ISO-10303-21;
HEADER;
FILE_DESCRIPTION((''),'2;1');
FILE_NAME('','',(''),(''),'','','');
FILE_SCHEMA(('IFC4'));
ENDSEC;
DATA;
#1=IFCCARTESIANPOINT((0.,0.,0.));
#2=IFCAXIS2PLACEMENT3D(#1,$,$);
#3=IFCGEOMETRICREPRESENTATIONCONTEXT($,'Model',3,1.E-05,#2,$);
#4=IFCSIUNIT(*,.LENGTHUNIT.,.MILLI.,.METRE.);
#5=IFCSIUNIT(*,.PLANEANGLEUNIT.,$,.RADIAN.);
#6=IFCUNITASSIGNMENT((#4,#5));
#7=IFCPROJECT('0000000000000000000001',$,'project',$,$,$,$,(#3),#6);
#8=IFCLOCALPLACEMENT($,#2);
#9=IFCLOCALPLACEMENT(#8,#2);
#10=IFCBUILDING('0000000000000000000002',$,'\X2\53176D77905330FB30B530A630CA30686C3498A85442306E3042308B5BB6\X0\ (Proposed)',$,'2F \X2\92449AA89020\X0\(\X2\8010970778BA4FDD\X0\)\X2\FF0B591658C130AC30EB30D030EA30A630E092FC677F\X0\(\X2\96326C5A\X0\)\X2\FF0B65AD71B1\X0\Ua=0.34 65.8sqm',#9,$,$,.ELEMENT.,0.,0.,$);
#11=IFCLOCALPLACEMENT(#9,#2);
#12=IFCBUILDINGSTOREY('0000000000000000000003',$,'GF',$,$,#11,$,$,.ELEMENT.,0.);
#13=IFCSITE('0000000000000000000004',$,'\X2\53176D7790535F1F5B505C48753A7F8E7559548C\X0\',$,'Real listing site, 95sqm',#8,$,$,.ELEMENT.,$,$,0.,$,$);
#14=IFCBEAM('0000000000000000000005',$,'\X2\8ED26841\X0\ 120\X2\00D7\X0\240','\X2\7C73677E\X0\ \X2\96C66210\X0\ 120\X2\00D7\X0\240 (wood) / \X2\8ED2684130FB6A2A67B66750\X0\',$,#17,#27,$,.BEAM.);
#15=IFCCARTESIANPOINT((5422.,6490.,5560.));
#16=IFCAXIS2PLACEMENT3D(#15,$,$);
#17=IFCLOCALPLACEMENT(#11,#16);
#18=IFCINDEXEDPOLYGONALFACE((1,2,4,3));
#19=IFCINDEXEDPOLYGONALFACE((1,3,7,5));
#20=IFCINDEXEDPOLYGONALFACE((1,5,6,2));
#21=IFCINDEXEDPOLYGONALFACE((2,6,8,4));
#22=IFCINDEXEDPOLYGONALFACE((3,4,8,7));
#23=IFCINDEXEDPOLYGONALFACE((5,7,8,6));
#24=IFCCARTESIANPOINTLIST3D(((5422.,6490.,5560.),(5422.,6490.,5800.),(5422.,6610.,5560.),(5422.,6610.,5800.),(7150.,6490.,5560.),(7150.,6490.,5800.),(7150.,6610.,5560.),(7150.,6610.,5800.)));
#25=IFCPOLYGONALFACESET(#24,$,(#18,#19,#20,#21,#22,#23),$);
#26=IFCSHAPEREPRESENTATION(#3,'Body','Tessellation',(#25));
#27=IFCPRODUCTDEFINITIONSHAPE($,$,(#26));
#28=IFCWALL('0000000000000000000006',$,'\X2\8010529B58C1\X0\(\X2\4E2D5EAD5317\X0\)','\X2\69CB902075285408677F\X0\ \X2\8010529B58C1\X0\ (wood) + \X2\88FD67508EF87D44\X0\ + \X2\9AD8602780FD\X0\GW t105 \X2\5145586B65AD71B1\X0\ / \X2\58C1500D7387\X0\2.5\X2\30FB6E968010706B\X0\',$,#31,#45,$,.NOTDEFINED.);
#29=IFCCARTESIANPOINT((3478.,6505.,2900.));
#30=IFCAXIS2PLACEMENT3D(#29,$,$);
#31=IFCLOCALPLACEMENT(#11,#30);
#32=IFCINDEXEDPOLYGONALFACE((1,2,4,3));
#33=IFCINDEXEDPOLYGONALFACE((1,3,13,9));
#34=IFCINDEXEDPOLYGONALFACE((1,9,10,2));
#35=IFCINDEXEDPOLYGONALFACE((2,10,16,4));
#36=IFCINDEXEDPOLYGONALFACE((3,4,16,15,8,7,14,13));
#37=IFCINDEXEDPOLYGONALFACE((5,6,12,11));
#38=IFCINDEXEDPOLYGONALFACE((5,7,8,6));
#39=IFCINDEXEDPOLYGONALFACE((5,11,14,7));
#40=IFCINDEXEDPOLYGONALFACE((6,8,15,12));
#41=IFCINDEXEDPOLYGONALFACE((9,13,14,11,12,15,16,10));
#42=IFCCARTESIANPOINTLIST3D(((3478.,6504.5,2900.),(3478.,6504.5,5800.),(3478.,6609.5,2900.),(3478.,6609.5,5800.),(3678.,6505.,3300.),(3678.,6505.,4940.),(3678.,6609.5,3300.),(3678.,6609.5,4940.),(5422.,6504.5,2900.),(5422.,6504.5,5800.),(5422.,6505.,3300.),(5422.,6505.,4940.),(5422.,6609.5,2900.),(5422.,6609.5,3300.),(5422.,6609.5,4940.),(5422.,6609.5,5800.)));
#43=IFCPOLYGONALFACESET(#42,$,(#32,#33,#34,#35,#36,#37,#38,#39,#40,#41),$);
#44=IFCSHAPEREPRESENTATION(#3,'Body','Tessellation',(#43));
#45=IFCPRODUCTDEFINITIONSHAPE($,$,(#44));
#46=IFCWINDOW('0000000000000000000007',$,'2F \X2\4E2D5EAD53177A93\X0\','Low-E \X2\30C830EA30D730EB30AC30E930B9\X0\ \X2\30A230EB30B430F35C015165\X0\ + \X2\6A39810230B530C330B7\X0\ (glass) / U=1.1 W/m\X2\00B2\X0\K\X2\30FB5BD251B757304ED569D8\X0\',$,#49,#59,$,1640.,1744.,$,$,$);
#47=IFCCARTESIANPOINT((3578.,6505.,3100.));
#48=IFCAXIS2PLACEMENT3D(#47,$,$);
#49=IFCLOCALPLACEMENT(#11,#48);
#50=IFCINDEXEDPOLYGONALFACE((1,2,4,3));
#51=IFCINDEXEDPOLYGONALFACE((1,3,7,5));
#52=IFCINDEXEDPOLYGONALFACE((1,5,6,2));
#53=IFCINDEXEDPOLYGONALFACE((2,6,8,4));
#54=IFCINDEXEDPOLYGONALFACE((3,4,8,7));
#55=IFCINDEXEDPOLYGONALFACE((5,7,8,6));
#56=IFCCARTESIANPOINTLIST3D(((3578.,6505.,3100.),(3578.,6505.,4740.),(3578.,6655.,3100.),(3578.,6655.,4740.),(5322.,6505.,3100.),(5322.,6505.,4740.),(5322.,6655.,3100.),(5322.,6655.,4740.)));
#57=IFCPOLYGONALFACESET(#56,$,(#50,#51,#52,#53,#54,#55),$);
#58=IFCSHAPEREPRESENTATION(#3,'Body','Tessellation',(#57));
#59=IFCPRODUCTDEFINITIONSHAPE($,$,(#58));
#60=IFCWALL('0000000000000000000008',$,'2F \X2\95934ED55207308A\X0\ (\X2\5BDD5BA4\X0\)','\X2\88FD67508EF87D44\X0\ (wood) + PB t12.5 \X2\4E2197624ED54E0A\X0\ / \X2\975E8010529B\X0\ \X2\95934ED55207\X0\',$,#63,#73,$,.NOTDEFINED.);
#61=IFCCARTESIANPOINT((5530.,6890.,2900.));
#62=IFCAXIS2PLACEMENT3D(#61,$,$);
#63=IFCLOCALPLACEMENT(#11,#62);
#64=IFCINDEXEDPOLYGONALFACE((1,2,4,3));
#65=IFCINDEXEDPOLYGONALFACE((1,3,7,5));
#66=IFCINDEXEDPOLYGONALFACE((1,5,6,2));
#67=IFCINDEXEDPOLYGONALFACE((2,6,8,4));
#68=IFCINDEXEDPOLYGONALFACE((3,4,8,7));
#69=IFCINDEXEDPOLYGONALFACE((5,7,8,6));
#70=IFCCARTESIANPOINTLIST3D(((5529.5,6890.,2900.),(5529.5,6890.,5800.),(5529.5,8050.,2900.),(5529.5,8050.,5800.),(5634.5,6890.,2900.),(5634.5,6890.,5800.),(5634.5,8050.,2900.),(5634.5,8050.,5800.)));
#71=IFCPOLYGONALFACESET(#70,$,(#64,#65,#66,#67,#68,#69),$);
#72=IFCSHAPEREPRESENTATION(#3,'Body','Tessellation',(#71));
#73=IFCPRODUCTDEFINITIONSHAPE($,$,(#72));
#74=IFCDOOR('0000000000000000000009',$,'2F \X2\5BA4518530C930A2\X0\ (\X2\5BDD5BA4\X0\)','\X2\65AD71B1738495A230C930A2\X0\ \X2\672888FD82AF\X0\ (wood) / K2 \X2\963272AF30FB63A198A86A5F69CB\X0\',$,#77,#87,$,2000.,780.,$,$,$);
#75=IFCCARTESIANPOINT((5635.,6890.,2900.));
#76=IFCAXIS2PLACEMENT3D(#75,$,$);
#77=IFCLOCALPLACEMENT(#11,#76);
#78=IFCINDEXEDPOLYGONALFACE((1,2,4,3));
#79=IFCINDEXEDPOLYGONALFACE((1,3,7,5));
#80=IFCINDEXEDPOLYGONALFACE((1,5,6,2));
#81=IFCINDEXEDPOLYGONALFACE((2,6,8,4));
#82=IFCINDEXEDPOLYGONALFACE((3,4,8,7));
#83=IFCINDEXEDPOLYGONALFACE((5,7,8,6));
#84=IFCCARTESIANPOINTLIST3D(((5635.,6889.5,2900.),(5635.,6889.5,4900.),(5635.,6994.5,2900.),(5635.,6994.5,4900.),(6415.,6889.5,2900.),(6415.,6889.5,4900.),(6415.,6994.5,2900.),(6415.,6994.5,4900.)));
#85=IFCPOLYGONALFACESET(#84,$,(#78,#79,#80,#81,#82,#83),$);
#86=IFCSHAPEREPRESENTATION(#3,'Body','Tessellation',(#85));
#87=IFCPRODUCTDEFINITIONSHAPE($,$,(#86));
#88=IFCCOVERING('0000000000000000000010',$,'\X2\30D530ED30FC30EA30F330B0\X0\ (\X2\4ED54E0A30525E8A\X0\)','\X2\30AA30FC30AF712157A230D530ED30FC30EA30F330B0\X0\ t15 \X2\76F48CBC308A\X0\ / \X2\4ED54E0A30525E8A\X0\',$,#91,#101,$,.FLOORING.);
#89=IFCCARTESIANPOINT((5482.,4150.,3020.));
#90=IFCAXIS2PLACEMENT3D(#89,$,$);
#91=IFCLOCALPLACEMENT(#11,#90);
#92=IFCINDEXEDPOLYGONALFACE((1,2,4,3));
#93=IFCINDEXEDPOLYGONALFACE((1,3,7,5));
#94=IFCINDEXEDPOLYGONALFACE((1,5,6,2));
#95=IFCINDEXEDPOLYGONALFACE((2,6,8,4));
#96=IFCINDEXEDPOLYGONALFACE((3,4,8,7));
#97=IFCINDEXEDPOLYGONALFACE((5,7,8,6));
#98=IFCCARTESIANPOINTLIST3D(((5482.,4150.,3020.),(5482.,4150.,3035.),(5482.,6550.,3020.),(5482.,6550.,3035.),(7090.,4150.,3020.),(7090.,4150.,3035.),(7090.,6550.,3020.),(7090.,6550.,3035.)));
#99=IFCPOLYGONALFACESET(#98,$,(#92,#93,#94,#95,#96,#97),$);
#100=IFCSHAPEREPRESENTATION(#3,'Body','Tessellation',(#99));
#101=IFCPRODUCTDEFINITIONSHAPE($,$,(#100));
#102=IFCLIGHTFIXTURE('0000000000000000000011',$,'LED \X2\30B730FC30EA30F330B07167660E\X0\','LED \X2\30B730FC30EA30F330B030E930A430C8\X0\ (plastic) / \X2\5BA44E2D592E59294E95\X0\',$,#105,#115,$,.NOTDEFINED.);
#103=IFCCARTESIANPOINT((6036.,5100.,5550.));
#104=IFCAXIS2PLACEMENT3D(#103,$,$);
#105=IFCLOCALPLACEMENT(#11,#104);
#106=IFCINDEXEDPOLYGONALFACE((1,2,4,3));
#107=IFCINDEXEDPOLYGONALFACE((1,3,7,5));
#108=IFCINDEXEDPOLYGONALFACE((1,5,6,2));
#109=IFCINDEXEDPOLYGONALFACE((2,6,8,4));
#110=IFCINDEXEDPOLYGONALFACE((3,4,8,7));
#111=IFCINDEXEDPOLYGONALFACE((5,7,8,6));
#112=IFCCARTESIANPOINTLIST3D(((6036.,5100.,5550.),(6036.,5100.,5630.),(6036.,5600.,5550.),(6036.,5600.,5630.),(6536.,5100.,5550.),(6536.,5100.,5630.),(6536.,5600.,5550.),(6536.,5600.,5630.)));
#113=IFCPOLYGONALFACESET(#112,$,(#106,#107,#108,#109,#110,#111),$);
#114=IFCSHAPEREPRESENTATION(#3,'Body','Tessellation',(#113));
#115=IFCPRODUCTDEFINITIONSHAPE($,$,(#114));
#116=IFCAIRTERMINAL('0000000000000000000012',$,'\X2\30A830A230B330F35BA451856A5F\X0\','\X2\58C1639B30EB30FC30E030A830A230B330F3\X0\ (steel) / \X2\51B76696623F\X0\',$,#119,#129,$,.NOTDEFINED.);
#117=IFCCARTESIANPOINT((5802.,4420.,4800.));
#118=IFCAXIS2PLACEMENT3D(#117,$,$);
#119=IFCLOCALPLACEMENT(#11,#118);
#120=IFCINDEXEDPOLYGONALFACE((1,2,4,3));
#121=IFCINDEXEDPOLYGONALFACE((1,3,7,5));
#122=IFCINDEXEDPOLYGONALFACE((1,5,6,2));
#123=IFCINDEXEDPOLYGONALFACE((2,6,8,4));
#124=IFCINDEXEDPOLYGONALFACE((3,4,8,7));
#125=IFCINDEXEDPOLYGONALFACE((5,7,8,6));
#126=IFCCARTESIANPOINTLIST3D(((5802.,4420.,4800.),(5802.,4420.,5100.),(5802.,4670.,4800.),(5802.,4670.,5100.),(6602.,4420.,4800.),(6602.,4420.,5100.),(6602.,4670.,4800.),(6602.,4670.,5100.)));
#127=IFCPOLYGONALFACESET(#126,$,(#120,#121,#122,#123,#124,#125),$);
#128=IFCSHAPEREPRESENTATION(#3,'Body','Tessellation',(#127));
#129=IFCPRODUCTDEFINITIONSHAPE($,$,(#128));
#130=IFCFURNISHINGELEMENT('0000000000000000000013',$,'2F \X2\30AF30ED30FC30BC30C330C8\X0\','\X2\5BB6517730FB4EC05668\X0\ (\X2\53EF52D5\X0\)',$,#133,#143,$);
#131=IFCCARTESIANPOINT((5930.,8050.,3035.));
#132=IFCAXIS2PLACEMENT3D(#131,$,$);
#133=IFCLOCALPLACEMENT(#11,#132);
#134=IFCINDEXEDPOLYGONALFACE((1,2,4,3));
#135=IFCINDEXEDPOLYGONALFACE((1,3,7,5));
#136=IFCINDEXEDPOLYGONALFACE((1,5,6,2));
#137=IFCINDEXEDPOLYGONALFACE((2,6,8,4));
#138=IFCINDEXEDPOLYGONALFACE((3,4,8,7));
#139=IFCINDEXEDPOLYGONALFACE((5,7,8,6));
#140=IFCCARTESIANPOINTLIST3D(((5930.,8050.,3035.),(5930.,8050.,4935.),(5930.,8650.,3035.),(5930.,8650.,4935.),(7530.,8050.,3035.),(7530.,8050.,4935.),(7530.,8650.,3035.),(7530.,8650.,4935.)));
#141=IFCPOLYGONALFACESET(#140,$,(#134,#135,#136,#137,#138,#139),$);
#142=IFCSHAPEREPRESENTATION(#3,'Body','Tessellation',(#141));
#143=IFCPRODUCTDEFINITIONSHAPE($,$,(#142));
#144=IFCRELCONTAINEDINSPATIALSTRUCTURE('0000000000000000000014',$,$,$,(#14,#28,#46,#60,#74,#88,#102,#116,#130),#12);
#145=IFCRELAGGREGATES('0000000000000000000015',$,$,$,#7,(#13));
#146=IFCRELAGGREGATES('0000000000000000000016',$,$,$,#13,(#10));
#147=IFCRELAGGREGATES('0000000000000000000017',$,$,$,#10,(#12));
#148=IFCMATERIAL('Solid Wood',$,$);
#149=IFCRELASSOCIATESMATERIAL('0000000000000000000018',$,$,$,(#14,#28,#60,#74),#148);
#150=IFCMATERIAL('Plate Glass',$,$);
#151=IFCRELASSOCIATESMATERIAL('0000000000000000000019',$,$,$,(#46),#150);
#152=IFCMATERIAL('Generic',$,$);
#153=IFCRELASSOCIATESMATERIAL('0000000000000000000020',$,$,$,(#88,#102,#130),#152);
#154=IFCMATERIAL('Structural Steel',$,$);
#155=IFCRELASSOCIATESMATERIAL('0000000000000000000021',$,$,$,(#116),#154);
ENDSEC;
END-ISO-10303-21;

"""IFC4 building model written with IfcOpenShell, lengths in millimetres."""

from ifc_helpers import new_model, si_unit, frame, frame_2d, origin, place, context, project, spatial, rectangle, extrude, material, element, fill, save


model = new_model("IFC4")

# Units and contexts
model_context = context("Model", 3, precision=1e-05, world=origin())
ifc_project = project(units=[si_unit("LENGTHUNIT", "METRE", prefix="MILLI"), si_unit("PLANEANGLEUNIT", "RADIAN")], contexts=[model_context])

# Site, building, storey
site_placement = place(None, origin())
site = spatial("IfcSite", under=ifc_project, at=site_placement, Name="北海道弟子屈町美留和", ObjectType="Real listing site, 95sqm", CompositionType="ELEMENT", RefElevation=0.0)
building_placement = place(site_placement, origin())
building = spatial("IfcBuilding", under=site, at=building_placement, Name="北海道・サウナと水風呂のある家 (Proposed)", ObjectType="2F 鉄骨造(耐震確保)＋外壁ガルバリウム鋼板(防汚)＋断熱Ua=0.34 65.8sqm", CompositionType="ELEMENT", ElevationOfRefHeight=0.0, ElevationOfTerrain=0.0)
storey_placement = place(building_placement, origin())
storey = spatial("IfcBuildingStorey", under=building, at=storey_placement, Name="GF", CompositionType="ELEMENT", Elevation=0.0)

# Shared definitions
ifc_material_1 = material(Name="Solid Wood")

# Beam
beam_1_placement = place(storey_placement, frame((5422.0, 6490.0, 5560.0)))
element("IfcBeam", 1, at=beam_1_placement, inside=storey, material=ifc_material_1, Name="軒桁 120×240", Description="米松 集成 120×240 (wood) / 軒桁・横架材", PredefinedType="BEAM", context=model_context, shape_type="SweptSolid", body=[
    extrude(rectangle(XDim=1728.0, YDim=120.0, at=frame_2d((864.0, 60.0))), frame((5422.0, 6490.0, 5560.0)), (0.0, 0.0, 1.0), 240.0),
])

# Wall, opening, window
wall_1_placement = place(storey_placement, frame((3478.0, 6505.0, 2900.0)))
wall_1 = element("IfcWall", 2, at=wall_1_placement, inside=storey, material=ifc_material_1, Name="耐力壁(中庭北)", Description="構造用合板 耐力壁 (wood) + 製材軸組 + 高性能GW t105 充填断熱 / 壁倍率2.5・準耐火", PredefinedType="NOTDEFINED", context=model_context, shape_type="SweptSolid", body=[
    extrude(rectangle(XDim=1944.0, YDim=105.0, at=frame_2d((972.0, 52.0))), frame((3478.0, 6505.0, 2900.0)), (0.0, 0.0, 1.0), 2900.0),
])
opening_placement = place(storey_placement, frame((3578.0, 6505.0, 3100.0)))
opening = element("IfcOpeningElement", 3, at=opening_placement, cuts=wall_1, PredefinedType="NOTDEFINED", context=model_context, shape_type="SweptSolid", body=[
    extrude(rectangle(XDim=1744.0, YDim=150.0, at=frame_2d((872.0, 75.0))), frame((3578.0, 6505.0, 3100.0)), (0.0, 0.0, 1.0), 1640.0),
])
ifc_material_2 = material(Name="Plate Glass")
window_placement = place(storey_placement, frame((3578.0, 6505.0, 3100.0)))
window = element("IfcWindow", 4, at=window_placement, inside=storey, material=ifc_material_2, Name="2F 中庭北窓", Description="Low-E トリプルガラス アルゴン封入 + 樹脂サッシ (glass) / U=1.1 W/m²K・寒冷地仕様", OverallHeight=1640.0, OverallWidth=1744.0, context=model_context, shape_type="SweptSolid", body=[
    extrude(rectangle(XDim=1744.0, YDim=150.0, at=frame_2d((872.0, 75.0))), frame((3578.0, 6505.0, 3100.0)), (0.0, 0.0, 1.0), 1640.0),
])
fill(opening, window)

# Wall
wall_2_placement = place(storey_placement, frame((5530.0, 6890.0, 2900.0)))
element("IfcWall", 5, at=wall_2_placement, inside=storey, material=ifc_material_1, Name="2F 間仕切り (寝室)", Description="製材軸組 (wood) + PB t12.5 両面仕上 / 非耐力 間仕切", PredefinedType="NOTDEFINED", context=model_context, shape_type="SweptSolid", body=[
    extrude(rectangle(XDim=105.0, YDim=1160.0, at=frame_2d((52.0, 580.0))), frame((5530.0, 6890.0, 2900.0)), (0.0, 0.0, 1.0), 2900.0),
])

# Door
door_placement = place(storey_placement, frame((5635.0, 6890.0, 2900.0)))
element("IfcDoor", 6, at=door_placement, inside=storey, material=ifc_material_1, Name="2F 室内ドア (寝室)", Description="断熱玄関ドア 木製芯 (wood) / K2 防犯・採風機構", OverallHeight=2000.0, OverallWidth=780.0, context=model_context, shape_type="SweptSolid", body=[
    extrude(rectangle(XDim=780.0, YDim=105.0, at=frame_2d((390.0, 52.0))), frame((5635.0, 6890.0, 2900.0)), (0.0, 0.0, 1.0), 2000.0),
])

# Covering
ifc_material_3 = material(Name="Generic")
covering_placement = place(storey_placement, frame((5482.0, 4150.0, 3020.0)))
element("IfcCovering", 7, at=covering_placement, inside=storey, material=ifc_material_3, Name="フローリング (仕上げ床)", Description="オーク無垢フローリング t15 直貼り / 仕上げ床", PredefinedType="FLOORING", context=model_context, shape_type="SweptSolid", body=[
    extrude(rectangle(XDim=1608.0, YDim=2400.0, at=frame_2d((804.0, 1200.0))), frame((5482.0, 4150.0, 3020.0)), (0.0, 0.0, 1.0), 15.0),
])

# Light fixture
light_fixture_placement = place(storey_placement, frame((6036.0, 5100.0, 5550.0)))
element("IfcLightFixture", 8, at=light_fixture_placement, inside=storey, material=ifc_material_3, Name="LED シーリング照明", Description="LED シーリングライト (plastic) / 室中央天井", PredefinedType="NOTDEFINED", context=model_context, shape_type="SweptSolid", body=[
    extrude(rectangle(XDim=500.0, YDim=500.0, at=frame_2d((250.0, 250.0))), frame((6036.0, 5100.0, 5550.0)), (0.0, 0.0, 1.0), 80.0),
])

# Air terminal
ifc_material_4 = material(Name="Structural Steel")
air_terminal_placement = place(storey_placement, frame((5802.0, 4420.0, 4800.0)))
element("IfcAirTerminal", 9, at=air_terminal_placement, inside=storey, material=ifc_material_4, Name="エアコン室内機", Description="壁掛ルームエアコン (steel) / 冷暖房", PredefinedType="NOTDEFINED", context=model_context, shape_type="SweptSolid", body=[
    extrude(rectangle(XDim=800.0, YDim=250.0, at=frame_2d((400.0, 125.0))), frame((5802.0, 4420.0, 4800.0)), (0.0, 0.0, 1.0), 300.0),
])

# Furnishing element
furnishing_placement = place(storey_placement, frame((5930.0, 8050.0, 3035.0)))
element("IfcFurnishingElement", 10, at=furnishing_placement, inside=storey, material=ifc_material_3, Name="2F クローゼット", Description="家具・什器 (可動)", context=model_context, shape_type="SweptSolid", body=[
    extrude(rectangle(XDim=1600.0, YDim=600.0, at=frame_2d((800.0, 300.0))), frame((5930.0, 8050.0, 3035.0)), (0.0, 0.0, 1.0), 1900.0),
])

save(model, "model.ifc")
